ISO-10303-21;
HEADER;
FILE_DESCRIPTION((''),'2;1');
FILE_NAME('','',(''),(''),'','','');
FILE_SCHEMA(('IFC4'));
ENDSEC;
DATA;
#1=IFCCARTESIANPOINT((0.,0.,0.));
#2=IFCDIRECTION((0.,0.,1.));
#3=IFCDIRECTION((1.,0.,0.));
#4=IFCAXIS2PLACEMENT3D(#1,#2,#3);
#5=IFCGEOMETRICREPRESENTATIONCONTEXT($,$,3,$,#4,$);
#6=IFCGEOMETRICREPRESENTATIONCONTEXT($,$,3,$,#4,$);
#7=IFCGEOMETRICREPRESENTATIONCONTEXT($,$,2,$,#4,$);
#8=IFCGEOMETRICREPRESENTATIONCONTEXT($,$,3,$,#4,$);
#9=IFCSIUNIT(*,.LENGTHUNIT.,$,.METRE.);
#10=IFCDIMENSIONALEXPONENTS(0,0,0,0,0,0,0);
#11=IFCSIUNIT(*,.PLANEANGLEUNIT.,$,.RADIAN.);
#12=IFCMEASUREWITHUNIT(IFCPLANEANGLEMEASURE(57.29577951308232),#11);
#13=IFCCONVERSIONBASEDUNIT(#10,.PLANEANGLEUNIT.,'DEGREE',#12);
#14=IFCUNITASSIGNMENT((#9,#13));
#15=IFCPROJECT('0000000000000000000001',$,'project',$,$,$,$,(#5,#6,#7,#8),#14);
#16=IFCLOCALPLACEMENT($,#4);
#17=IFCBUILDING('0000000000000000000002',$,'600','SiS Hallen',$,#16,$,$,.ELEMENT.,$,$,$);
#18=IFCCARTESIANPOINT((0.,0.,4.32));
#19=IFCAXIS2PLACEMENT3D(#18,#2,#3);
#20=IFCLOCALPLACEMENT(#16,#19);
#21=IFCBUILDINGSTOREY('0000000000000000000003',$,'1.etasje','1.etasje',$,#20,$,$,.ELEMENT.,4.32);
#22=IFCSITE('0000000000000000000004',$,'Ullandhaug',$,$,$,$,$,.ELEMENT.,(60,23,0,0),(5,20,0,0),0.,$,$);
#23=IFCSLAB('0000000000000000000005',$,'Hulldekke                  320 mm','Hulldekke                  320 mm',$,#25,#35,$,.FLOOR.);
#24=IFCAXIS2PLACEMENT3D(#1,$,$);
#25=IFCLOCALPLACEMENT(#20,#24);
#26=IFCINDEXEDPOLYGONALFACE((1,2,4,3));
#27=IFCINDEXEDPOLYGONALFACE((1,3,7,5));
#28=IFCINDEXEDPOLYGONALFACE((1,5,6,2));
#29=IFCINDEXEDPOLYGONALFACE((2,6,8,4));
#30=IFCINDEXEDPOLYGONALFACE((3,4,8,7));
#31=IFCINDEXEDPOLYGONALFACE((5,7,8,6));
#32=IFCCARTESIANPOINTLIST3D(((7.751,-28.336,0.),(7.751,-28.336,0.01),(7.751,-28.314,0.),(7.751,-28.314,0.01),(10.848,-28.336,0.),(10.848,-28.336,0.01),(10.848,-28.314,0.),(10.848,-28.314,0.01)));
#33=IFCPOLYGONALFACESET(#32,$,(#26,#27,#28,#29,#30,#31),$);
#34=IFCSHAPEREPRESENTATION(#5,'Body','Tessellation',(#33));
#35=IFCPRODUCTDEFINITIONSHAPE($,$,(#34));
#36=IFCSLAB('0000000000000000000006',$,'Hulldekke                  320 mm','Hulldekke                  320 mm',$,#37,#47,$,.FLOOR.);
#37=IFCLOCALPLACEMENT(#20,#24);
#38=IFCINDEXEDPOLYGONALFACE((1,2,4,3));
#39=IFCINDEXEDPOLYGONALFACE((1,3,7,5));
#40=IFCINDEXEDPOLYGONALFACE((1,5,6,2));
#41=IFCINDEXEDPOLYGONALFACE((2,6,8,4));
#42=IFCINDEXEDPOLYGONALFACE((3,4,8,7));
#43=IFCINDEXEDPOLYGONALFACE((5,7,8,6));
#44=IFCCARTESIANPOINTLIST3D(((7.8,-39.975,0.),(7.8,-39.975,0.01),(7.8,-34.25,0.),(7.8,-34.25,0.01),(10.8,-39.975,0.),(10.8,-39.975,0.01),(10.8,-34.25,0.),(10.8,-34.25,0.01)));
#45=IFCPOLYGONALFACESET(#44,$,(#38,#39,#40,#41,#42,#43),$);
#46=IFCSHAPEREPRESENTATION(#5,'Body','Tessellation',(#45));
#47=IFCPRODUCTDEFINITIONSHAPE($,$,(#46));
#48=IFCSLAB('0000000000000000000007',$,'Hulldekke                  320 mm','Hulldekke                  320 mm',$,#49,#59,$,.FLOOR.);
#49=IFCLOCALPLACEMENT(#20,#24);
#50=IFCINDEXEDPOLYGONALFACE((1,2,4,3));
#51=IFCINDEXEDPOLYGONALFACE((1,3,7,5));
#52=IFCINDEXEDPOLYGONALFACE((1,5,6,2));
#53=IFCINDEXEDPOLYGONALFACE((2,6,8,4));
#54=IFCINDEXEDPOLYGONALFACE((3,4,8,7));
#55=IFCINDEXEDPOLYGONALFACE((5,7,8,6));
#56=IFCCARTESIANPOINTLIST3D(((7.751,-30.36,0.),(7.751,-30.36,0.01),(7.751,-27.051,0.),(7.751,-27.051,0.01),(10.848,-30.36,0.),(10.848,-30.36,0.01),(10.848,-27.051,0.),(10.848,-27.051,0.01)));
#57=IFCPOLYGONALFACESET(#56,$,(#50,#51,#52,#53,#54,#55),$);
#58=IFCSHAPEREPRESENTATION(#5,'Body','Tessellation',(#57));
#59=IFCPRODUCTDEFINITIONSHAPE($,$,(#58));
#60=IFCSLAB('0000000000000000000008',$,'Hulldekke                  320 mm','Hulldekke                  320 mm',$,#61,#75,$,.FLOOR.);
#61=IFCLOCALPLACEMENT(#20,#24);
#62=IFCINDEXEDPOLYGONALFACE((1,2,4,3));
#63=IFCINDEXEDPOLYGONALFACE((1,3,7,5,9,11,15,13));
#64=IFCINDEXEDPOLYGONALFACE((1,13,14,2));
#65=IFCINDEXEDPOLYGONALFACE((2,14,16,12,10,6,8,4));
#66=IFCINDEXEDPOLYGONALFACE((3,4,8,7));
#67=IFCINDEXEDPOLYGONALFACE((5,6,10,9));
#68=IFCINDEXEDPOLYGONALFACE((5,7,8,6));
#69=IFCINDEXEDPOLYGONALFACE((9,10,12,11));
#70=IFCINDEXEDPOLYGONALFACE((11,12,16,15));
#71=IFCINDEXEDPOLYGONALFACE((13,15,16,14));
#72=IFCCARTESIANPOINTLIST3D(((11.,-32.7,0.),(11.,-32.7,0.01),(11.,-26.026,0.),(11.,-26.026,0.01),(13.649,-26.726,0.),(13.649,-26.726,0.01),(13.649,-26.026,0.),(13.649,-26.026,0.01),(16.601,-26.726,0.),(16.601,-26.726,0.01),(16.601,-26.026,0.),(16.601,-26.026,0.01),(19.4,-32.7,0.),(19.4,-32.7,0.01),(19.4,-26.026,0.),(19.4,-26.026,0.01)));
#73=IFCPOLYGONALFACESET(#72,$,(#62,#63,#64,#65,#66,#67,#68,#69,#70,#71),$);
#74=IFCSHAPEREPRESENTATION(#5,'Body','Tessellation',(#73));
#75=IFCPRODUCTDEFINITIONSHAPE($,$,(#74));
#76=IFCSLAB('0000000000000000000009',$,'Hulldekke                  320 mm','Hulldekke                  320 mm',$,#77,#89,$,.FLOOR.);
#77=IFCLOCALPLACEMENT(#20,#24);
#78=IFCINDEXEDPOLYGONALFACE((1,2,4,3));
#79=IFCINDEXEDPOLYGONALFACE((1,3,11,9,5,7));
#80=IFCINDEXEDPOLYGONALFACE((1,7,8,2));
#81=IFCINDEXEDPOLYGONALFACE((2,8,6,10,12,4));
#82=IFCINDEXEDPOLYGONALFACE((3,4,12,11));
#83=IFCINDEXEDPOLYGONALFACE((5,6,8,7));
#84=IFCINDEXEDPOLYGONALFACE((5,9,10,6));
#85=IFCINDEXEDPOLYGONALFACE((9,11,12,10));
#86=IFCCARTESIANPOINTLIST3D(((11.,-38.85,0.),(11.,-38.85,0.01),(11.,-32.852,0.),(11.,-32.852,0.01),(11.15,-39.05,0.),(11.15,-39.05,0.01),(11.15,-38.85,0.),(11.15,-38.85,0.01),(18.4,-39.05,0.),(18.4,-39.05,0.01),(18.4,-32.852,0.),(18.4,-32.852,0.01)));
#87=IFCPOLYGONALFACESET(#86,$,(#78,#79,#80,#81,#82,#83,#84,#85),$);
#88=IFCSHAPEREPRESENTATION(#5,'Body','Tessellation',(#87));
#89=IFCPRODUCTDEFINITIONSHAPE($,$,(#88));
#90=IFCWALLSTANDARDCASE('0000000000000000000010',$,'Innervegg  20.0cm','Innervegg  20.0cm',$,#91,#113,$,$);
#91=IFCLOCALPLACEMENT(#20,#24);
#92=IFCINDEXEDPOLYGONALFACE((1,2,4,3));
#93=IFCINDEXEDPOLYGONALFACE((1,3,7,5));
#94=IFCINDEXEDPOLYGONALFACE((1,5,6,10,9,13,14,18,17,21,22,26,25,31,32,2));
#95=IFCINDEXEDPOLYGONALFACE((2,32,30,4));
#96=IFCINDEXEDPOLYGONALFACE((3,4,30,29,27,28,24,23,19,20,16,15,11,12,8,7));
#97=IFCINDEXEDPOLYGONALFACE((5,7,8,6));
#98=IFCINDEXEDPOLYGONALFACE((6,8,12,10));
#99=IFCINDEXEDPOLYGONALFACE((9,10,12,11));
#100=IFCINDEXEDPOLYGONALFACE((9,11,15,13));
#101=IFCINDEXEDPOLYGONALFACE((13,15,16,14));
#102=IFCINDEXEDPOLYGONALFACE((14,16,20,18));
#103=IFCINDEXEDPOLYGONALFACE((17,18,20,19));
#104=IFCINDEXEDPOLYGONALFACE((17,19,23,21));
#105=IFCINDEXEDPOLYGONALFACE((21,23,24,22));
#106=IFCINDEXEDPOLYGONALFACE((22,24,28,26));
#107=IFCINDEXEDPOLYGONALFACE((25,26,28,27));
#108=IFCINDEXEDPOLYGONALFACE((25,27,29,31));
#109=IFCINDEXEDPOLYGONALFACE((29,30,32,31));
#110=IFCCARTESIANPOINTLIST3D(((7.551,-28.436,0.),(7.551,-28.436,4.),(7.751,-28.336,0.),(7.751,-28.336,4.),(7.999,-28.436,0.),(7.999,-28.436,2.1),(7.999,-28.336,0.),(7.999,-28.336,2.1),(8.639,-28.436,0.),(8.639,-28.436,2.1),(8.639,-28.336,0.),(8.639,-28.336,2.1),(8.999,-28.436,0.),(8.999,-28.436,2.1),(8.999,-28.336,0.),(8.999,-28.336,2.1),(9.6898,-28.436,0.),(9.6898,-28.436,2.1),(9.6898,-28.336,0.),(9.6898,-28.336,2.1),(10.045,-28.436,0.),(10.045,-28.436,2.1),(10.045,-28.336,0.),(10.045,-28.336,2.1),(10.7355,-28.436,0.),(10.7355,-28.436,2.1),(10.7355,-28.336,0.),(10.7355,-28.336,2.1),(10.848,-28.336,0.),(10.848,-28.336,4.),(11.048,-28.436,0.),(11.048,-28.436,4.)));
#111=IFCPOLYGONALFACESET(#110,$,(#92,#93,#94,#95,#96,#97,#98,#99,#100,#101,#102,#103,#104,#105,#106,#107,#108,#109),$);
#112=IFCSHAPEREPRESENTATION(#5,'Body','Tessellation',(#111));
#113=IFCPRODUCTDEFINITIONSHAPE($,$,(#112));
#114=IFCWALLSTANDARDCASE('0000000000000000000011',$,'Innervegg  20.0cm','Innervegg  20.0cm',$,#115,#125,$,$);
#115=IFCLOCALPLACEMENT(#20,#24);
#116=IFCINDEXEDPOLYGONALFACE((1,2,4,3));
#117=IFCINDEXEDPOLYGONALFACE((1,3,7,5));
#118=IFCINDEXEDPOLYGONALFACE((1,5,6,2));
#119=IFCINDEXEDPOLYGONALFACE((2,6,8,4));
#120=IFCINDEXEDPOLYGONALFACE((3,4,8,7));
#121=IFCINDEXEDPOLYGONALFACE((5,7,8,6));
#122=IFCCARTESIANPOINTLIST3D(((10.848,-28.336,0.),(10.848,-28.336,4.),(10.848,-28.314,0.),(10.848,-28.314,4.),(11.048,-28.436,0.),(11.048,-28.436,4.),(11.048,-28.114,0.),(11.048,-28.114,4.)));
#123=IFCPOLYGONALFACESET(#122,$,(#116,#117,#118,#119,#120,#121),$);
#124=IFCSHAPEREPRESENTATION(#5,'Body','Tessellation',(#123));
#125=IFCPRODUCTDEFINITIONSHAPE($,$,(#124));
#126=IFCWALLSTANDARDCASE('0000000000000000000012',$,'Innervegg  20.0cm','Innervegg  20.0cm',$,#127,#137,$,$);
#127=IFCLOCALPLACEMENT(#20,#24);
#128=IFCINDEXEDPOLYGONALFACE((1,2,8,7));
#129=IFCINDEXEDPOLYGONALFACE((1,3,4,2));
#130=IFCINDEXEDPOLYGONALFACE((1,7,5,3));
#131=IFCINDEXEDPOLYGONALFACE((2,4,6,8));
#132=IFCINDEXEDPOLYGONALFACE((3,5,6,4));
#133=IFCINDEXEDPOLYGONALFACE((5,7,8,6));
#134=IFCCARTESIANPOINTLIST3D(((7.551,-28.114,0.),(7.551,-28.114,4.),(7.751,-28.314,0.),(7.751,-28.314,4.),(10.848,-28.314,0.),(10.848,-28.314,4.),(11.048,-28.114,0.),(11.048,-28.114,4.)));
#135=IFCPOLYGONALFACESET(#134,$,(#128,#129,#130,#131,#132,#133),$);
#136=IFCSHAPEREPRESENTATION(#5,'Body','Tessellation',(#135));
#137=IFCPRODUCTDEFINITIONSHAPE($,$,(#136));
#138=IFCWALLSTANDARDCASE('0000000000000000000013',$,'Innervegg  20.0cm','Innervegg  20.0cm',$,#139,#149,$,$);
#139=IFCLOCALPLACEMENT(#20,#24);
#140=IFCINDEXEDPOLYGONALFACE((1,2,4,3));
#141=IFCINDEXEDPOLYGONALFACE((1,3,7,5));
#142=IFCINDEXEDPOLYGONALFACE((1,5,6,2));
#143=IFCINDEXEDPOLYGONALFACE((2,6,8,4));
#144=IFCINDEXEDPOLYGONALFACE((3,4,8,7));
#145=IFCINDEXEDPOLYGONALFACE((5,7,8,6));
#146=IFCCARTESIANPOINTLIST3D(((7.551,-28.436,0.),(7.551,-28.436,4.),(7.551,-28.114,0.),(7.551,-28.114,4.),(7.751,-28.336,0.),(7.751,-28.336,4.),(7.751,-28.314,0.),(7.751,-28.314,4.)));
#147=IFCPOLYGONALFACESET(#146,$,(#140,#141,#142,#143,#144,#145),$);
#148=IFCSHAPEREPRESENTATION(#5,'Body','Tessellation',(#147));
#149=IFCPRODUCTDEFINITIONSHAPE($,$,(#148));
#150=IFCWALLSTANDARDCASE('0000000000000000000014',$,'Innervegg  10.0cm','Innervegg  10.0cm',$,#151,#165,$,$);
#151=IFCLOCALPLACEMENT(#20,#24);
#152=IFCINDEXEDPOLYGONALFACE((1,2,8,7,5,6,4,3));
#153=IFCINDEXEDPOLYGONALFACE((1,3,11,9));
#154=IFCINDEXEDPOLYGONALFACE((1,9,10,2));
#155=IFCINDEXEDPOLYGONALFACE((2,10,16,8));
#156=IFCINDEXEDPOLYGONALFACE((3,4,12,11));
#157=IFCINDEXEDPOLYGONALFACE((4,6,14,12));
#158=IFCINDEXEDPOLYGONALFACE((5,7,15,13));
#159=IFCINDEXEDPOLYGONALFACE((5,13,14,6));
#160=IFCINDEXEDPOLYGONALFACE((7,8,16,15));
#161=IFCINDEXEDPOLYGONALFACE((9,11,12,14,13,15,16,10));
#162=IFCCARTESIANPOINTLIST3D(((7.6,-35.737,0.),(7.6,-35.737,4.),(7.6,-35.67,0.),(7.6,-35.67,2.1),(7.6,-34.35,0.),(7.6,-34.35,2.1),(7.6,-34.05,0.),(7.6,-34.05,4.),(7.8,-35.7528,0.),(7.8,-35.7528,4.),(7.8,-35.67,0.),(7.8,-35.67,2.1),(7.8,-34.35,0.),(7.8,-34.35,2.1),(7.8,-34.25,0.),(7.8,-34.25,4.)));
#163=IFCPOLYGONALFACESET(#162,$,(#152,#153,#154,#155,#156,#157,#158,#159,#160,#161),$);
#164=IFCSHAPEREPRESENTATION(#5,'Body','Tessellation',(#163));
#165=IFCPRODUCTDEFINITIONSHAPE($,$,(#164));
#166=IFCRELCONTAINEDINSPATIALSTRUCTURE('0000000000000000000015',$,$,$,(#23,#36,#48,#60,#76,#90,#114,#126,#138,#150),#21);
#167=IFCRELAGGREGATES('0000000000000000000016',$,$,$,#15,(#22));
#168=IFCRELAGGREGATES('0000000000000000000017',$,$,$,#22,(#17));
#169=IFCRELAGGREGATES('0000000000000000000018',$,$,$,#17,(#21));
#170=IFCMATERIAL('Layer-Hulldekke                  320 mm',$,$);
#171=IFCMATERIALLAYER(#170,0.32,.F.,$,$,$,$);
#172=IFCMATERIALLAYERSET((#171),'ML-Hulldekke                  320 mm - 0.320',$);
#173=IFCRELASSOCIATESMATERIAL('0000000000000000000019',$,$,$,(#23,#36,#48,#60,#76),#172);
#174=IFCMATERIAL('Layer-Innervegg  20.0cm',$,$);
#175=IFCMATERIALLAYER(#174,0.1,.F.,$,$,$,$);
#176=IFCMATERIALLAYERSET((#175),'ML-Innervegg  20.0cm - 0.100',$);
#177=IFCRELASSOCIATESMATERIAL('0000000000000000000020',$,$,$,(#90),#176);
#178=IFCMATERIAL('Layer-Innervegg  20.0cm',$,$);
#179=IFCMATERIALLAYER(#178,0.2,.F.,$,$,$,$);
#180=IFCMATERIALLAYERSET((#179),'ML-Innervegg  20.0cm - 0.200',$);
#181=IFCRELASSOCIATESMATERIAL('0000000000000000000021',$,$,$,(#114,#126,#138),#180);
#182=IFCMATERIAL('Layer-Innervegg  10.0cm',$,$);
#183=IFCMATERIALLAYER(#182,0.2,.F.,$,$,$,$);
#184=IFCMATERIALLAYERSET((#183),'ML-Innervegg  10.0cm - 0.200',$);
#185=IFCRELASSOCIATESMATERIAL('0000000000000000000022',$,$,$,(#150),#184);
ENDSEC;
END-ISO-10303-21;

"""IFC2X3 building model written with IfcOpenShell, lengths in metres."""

from ifc_helpers import new_model, entity, si_unit, converted_unit, frame, origin_with_axes, place, context, project, spatial, polyline, outline, extrude, material, layer, layer_set, layer_usage, element, save


model = new_model("IFC2X3")

# Units and contexts
context_of_model_1 = context(None, 3, world=origin_with_axes())
context_of_model_2 = context(None, 3, world=origin_with_axes())
context_of_model_3 = context(None, 2, world=origin_with_axes())
context_of_model_4 = context(None, 3, world=origin_with_axes())
ifc_project = project(units=[si_unit("LENGTHUNIT", "METRE"), converted_unit("PLANEANGLEUNIT", "DEGREE", entity("IfcPlaneAngleMeasure", 57.29577951308232), si_unit("PLANEANGLEUNIT", "RADIAN"), dimensions=[0, 0, 0, 0, 0, 0, 0])], contexts=[context_of_model_1, context_of_model_2, context_of_model_3, context_of_model_4])

# Site, building, storey
site = spatial("IfcSite", under=ifc_project, Name="Ullandhaug", CompositionType="ELEMENT", RefLatitude=(60, 23, 0, 0), RefLongitude=(5, 20, 0, 0), RefElevation=0.0)
building_placement = place(None, origin_with_axes())
building = spatial("IfcBuilding", under=site, at=building_placement, Name="600", Description="SiS Hallen", CompositionType="ELEMENT")
storey_placement = place(building_placement, frame((0.0, 0.0, 4.32), z_axis=(0.0, 0.0, 1.0), x_axis=(1.0, 0.0, 0.0)))
storey = spatial("IfcBuildingStorey", under=building, at=storey_placement, Name="1.etasje", Description="1.etasje", CompositionType="ELEMENT", Elevation=4.32)

# Slabs
ifc_material_1 = material(Name="Layer-Hulldekke                  320 mm")
ifc_layer_1 = layer(ifc_material_1, 0.32, ventilated=False)
ifc_layer_set_1 = layer_set([ifc_layer_1], Name="ML-Hulldekke                  320 mm - 0.320")
ifc_layer_usage_1 = layer_usage(ifc_layer_set_1, "AXIS2", "POSITIVE", 0.0)
slab_1_placement = place(storey_placement, frame((7.751, -28.336, 0.0), z_axis=(0.0, 0.0, 1.0), x_axis=(1.0, 0.0, 0.0)))
element("IfcSlab", 1, at=slab_1_placement, inside=storey, material=ifc_layer_usage_1, Name="Hulldekke                  320 mm", Description="Hulldekke                  320 mm", PredefinedType="FLOOR", context=context_of_model_1, shape_type="SweptSolid", body=[
    extrude(outline(polyline([(0.0, 0.0), (3.097, 0.0), (3.097, 0.022), (0.0, 0.022), (0.0, 0.0)])), origin_with_axes(), (0.0, 0.0, 1.0), 0.01),
])
slab_2_placement = place(storey_placement, frame((7.8, -39.975, 0.0), z_axis=(0.0, 0.0, 1.0), x_axis=(1.0, 0.0, 0.0)))
element("IfcSlab", 2, at=slab_2_placement, inside=storey, material=ifc_layer_usage_1, Name="Hulldekke                  320 mm", Description="Hulldekke                  320 mm", PredefinedType="FLOOR", context=context_of_model_1, shape_type="SweptSolid", body=[
    extrude(outline(polyline([(0.0, 0.0), (3.0, 0.0), (3.0, 5.725), (0.0, 5.725), (0.0, 0.0)])), origin_with_axes(), (0.0, 0.0, 1.0), 0.01),
])
slab_3_placement = place(storey_placement, frame((7.751, -30.36, 0.0), z_axis=(0.0, 0.0, 1.0), x_axis=(1.0, 0.0, 0.0)))
element("IfcSlab", 3, at=slab_3_placement, inside=storey, material=ifc_layer_usage_1, Name="Hulldekke                  320 mm", Description="Hulldekke                  320 mm", PredefinedType="FLOOR", context=context_of_model_1, shape_type="SweptSolid", body=[
    extrude(outline(polyline([(0.0, 0.0), (3.097, 0.0), (3.097, 3.309), (0.0, 3.309), (0.0, 0.0)])), origin_with_axes(), (0.0, 0.0, 1.0), 0.01),
])
slab_4_placement = place(storey_placement, frame((11.0, -32.7, 0.0), z_axis=(0.0, 0.0, 1.0), x_axis=(1.0, 0.0, 0.0)))
element("IfcSlab", 4, at=slab_4_placement, inside=storey, material=ifc_layer_usage_1, Name="Hulldekke                  320 mm", Description="Hulldekke                  320 mm", PredefinedType="FLOOR", context=context_of_model_1, shape_type="SweptSolid", body=[
    extrude(outline(polyline([(0.0, 0.0), (8.4, 0.0), (8.4, 6.674), (5.601, 6.674), (5.601, 5.974), (2.649, 5.974), (2.649, 6.674), (0.0, 6.674), (0.0, 0.0)])), origin_with_axes(), (0.0, 0.0, 1.0), 0.01),
])
slab_5_placement = place(storey_placement, frame((11.15, -38.85, 0.0), z_axis=(0.0, 0.0, 1.0), x_axis=(1.0, 0.0, 0.0)))
element("IfcSlab", 5, at=slab_5_placement, inside=storey, material=ifc_layer_usage_1, Name="Hulldekke                  320 mm", Description="Hulldekke                  320 mm", PredefinedType="FLOOR", context=context_of_model_1, shape_type="SweptSolid", body=[
    extrude(outline(polyline([(0.0, 0.0), (0.2, 0.0), (0.2, 7.25), (-5.998, 7.25), (-5.998, -0.15), (0.0, -0.15), (0.0, 0.0)])), frame((0.0, 0.0, 0.0), z_axis=(0.0, 0.0, 1.0), x_axis=(0.0, -1.0, 0.0)), (0.0, 0.0, 1.0), 0.01),
])

# Wall, openings
ifc_material_2 = material(Name="Layer-Innervegg  20.0cm")
ifc_layer_2 = layer(ifc_material_2, 0.1, ventilated=False)
ifc_layer_set_2 = layer_set([ifc_layer_2], Name="ML-Innervegg  20.0cm - 0.100")
ifc_layer_usage_2 = layer_usage(ifc_layer_set_2, "AXIS2", "POSITIVE", 0.0)
wall_1_placement = place(storey_placement, frame((7.551, -28.436, 0.0), z_axis=(0.0, 0.0, 1.0), x_axis=(1.0, 0.0, 0.0)))
wall_1 = element("IfcWallStandardCase", 6, at=wall_1_placement, inside=storey, material=ifc_layer_usage_2, Name="Innervegg  20.0cm", Description="Innervegg  20.0cm", context=context_of_model_1, shape_type="SweptSolid", body=[
    extrude(outline(polyline([(0.0, 0.0), (3.497, 0.0), (3.297, 0.1), (0.2, 0.1), (0.0, 0.0)])), origin_with_axes(), (0.0, 0.0, 1.0), 4.0),
])
opening_1_placement = place(wall_1_placement, frame((0.448, 0.1, 0.0), z_axis=(0.0, 0.0, 1.0), x_axis=(1.0, 0.0, 0.0)))
element("IfcOpeningElement", 7, at=opening_1_placement, cuts=wall_1, context=context_of_model_1, shape_type="SweptSolid", body=[
    extrude(outline(polyline([(0.0, 0.0), (2.1, 0.0), (2.1, 0.64), (0.0, 0.64), (0.0, 0.0)])), frame((0.0, 0.0, 0.0), z_axis=(0.0, 1.0, 0.0), x_axis=(0.0, 0.0, 1.0)), (0.0, 0.0, -1.0), 0.1),
])
opening_2_placement = place(wall_1_placement, frame((1.448, 0.1, 0.0), z_axis=(0.0, 0.0, 1.0), x_axis=(1.0, 0.0, 0.0)))
element("IfcOpeningElement", 8, at=opening_2_placement, cuts=wall_1, context=context_of_model_1, shape_type="SweptSolid", body=[
    extrude(outline(polyline([(0.0, 0.0), (2.1, 0.0), (2.1, 0.6908), (0.0, 0.6908), (0.0, 0.0)])), frame((0.0, 0.0, 0.0), z_axis=(0.0, 1.0, 0.0), x_axis=(0.0, 0.0, 1.0)), (0.0, 0.0, -1.0), 0.1),
])
opening_3_placement = place(wall_1_placement, frame((2.494, 0.1, 0.0), z_axis=(0.0, 0.0, 1.0), x_axis=(1.0, 0.0, 0.0)))
element("IfcOpeningElement", 9, at=opening_3_placement, cuts=wall_1, context=context_of_model_1, shape_type="SweptSolid", body=[
    extrude(outline(polyline([(0.0, 0.0), (2.1, 0.0), (2.1, 0.6905), (0.0, 0.6905), (0.0, 0.0)])), frame((0.0, 0.0, 0.0), z_axis=(0.0, 1.0, 0.0), x_axis=(0.0, 0.0, 1.0)), (0.0, 0.0, -1.0), 0.1),
])

# Walls
ifc_material_3 = material(Name="Layer-Innervegg  20.0cm")
ifc_layer_3 = layer(ifc_material_3, 0.2, ventilated=False)
ifc_layer_set_3 = layer_set([ifc_layer_3], Name="ML-Innervegg  20.0cm - 0.200")
ifc_layer_usage_3 = layer_usage(ifc_layer_set_3, "AXIS2", "POSITIVE", 0.0)
wall_2_placement = place(storey_placement, frame((11.048, -28.436, 0.0), z_axis=(0.0, 0.0, 1.0), x_axis=(0.0, 1.0, 0.0)))
element("IfcWallStandardCase", 10, at=wall_2_placement, inside=storey, material=ifc_layer_usage_3, Name="Innervegg  20.0cm", Description="Innervegg  20.0cm", context=context_of_model_1, shape_type="SweptSolid", body=[
    extrude(outline(polyline([(0.0, 0.0), (0.322, 0.0), (0.122, 0.2), (0.1, 0.2), (0.0, 0.0)])), frame((0.0, 0.0, 0.0), z_axis=(0.0, 0.0, 1.0), x_axis=(1.0, 0.0, 0.0)), (0.0, 0.0, 1.0), 4.0),
])
wall_3_placement = place(storey_placement, frame((11.048, -28.114, 0.0), z_axis=(0.0, 0.0, 1.0), x_axis=(-1.0, 0.0, 0.0)))
element("IfcWallStandardCase", 11, at=wall_3_placement, inside=storey, material=ifc_layer_usage_3, Name="Innervegg  20.0cm", Description="Innervegg  20.0cm", context=context_of_model_1, shape_type="SweptSolid", body=[
    extrude(outline(polyline([(0.0, 0.0), (3.497, 0.0), (3.297, 0.2), (0.2, 0.2), (0.0, 0.0)])), frame((0.0, 0.0, 0.0), z_axis=(0.0, 0.0, 1.0), x_axis=(1.0, 0.0, 0.0)), (0.0, 0.0, 1.0), 4.0),
])
wall_4_placement = place(storey_placement, frame((7.551, -28.114, 0.0), z_axis=(0.0, 0.0, 1.0), x_axis=(0.0, -1.0, 0.0)))
element("IfcWallStandardCase", 12, at=wall_4_placement, inside=storey, material=ifc_layer_usage_3, Name="Innervegg  20.0cm", Description="Innervegg  20.0cm", context=context_of_model_1, shape_type="SweptSolid", body=[
    extrude(outline(polyline([(0.0, 0.0), (0.322, 0.0), (0.222, 0.2), (0.2, 0.2), (0.0, 0.0)])), frame((0.0, 0.0, 0.0), z_axis=(0.0, 0.0, 1.0), x_axis=(1.0, 0.0, 0.0)), (0.0, 0.0, 1.0), 4.0),
])

# Wall, opening
ifc_material_4 = material(Name="Layer-Innervegg  10.0cm")
ifc_layer_4 = layer(ifc_material_4, 0.2, ventilated=False)
ifc_layer_set_4 = layer_set([ifc_layer_4], Name="ML-Innervegg  10.0cm - 0.200")
ifc_layer_usage_4 = layer_usage(ifc_layer_set_4, "AXIS2", "POSITIVE", 0.0)
wall_5_placement = place(storey_placement, frame((7.8, -35.7528, 0.0), z_axis=(0.0, 0.0, 1.0), x_axis=(0.0, 1.0, 0.0)))
wall_5 = element("IfcWallStandardCase", 13, at=wall_5_placement, inside=storey, material=ifc_layer_usage_4, Name="Innervegg  10.0cm", Description="Innervegg  10.0cm", context=context_of_model_1, shape_type="SweptSolid", body=[
    extrude(outline(polyline([(0.0, 0.0), (1.5028, 0.0), (1.7027, 0.2), (0.0158, 0.2), (0.0, 0.0)])), frame((0.0, 0.0, 0.0), z_axis=(0.0, 0.0, 1.0), x_axis=(1.0, 0.0, 0.0)), (0.0, 0.0, 1.0), 4.0),
])
opening_4_placement = place(wall_5_placement, frame((0.0828, 0.2, 0.0), z_axis=(0.0, 0.0, 1.0), x_axis=(1.0, 0.0, 0.0)))
element("IfcOpeningElement", 14, at=opening_4_placement, cuts=wall_5, context=context_of_model_1, shape_type="SweptSolid", body=[
    extrude(outline(polyline([(0.0, 0.0), (2.1, 0.0), (2.1, 1.32), (0.0, 1.32), (0.0, 0.0)])), frame((0.0, 0.0, 0.0), z_axis=(0.0, 1.0, 0.0), x_axis=(0.0, 0.0, 1.0)), (0.0, 0.0, -1.0), 0.2),
])

save(model, "model.ifc")
